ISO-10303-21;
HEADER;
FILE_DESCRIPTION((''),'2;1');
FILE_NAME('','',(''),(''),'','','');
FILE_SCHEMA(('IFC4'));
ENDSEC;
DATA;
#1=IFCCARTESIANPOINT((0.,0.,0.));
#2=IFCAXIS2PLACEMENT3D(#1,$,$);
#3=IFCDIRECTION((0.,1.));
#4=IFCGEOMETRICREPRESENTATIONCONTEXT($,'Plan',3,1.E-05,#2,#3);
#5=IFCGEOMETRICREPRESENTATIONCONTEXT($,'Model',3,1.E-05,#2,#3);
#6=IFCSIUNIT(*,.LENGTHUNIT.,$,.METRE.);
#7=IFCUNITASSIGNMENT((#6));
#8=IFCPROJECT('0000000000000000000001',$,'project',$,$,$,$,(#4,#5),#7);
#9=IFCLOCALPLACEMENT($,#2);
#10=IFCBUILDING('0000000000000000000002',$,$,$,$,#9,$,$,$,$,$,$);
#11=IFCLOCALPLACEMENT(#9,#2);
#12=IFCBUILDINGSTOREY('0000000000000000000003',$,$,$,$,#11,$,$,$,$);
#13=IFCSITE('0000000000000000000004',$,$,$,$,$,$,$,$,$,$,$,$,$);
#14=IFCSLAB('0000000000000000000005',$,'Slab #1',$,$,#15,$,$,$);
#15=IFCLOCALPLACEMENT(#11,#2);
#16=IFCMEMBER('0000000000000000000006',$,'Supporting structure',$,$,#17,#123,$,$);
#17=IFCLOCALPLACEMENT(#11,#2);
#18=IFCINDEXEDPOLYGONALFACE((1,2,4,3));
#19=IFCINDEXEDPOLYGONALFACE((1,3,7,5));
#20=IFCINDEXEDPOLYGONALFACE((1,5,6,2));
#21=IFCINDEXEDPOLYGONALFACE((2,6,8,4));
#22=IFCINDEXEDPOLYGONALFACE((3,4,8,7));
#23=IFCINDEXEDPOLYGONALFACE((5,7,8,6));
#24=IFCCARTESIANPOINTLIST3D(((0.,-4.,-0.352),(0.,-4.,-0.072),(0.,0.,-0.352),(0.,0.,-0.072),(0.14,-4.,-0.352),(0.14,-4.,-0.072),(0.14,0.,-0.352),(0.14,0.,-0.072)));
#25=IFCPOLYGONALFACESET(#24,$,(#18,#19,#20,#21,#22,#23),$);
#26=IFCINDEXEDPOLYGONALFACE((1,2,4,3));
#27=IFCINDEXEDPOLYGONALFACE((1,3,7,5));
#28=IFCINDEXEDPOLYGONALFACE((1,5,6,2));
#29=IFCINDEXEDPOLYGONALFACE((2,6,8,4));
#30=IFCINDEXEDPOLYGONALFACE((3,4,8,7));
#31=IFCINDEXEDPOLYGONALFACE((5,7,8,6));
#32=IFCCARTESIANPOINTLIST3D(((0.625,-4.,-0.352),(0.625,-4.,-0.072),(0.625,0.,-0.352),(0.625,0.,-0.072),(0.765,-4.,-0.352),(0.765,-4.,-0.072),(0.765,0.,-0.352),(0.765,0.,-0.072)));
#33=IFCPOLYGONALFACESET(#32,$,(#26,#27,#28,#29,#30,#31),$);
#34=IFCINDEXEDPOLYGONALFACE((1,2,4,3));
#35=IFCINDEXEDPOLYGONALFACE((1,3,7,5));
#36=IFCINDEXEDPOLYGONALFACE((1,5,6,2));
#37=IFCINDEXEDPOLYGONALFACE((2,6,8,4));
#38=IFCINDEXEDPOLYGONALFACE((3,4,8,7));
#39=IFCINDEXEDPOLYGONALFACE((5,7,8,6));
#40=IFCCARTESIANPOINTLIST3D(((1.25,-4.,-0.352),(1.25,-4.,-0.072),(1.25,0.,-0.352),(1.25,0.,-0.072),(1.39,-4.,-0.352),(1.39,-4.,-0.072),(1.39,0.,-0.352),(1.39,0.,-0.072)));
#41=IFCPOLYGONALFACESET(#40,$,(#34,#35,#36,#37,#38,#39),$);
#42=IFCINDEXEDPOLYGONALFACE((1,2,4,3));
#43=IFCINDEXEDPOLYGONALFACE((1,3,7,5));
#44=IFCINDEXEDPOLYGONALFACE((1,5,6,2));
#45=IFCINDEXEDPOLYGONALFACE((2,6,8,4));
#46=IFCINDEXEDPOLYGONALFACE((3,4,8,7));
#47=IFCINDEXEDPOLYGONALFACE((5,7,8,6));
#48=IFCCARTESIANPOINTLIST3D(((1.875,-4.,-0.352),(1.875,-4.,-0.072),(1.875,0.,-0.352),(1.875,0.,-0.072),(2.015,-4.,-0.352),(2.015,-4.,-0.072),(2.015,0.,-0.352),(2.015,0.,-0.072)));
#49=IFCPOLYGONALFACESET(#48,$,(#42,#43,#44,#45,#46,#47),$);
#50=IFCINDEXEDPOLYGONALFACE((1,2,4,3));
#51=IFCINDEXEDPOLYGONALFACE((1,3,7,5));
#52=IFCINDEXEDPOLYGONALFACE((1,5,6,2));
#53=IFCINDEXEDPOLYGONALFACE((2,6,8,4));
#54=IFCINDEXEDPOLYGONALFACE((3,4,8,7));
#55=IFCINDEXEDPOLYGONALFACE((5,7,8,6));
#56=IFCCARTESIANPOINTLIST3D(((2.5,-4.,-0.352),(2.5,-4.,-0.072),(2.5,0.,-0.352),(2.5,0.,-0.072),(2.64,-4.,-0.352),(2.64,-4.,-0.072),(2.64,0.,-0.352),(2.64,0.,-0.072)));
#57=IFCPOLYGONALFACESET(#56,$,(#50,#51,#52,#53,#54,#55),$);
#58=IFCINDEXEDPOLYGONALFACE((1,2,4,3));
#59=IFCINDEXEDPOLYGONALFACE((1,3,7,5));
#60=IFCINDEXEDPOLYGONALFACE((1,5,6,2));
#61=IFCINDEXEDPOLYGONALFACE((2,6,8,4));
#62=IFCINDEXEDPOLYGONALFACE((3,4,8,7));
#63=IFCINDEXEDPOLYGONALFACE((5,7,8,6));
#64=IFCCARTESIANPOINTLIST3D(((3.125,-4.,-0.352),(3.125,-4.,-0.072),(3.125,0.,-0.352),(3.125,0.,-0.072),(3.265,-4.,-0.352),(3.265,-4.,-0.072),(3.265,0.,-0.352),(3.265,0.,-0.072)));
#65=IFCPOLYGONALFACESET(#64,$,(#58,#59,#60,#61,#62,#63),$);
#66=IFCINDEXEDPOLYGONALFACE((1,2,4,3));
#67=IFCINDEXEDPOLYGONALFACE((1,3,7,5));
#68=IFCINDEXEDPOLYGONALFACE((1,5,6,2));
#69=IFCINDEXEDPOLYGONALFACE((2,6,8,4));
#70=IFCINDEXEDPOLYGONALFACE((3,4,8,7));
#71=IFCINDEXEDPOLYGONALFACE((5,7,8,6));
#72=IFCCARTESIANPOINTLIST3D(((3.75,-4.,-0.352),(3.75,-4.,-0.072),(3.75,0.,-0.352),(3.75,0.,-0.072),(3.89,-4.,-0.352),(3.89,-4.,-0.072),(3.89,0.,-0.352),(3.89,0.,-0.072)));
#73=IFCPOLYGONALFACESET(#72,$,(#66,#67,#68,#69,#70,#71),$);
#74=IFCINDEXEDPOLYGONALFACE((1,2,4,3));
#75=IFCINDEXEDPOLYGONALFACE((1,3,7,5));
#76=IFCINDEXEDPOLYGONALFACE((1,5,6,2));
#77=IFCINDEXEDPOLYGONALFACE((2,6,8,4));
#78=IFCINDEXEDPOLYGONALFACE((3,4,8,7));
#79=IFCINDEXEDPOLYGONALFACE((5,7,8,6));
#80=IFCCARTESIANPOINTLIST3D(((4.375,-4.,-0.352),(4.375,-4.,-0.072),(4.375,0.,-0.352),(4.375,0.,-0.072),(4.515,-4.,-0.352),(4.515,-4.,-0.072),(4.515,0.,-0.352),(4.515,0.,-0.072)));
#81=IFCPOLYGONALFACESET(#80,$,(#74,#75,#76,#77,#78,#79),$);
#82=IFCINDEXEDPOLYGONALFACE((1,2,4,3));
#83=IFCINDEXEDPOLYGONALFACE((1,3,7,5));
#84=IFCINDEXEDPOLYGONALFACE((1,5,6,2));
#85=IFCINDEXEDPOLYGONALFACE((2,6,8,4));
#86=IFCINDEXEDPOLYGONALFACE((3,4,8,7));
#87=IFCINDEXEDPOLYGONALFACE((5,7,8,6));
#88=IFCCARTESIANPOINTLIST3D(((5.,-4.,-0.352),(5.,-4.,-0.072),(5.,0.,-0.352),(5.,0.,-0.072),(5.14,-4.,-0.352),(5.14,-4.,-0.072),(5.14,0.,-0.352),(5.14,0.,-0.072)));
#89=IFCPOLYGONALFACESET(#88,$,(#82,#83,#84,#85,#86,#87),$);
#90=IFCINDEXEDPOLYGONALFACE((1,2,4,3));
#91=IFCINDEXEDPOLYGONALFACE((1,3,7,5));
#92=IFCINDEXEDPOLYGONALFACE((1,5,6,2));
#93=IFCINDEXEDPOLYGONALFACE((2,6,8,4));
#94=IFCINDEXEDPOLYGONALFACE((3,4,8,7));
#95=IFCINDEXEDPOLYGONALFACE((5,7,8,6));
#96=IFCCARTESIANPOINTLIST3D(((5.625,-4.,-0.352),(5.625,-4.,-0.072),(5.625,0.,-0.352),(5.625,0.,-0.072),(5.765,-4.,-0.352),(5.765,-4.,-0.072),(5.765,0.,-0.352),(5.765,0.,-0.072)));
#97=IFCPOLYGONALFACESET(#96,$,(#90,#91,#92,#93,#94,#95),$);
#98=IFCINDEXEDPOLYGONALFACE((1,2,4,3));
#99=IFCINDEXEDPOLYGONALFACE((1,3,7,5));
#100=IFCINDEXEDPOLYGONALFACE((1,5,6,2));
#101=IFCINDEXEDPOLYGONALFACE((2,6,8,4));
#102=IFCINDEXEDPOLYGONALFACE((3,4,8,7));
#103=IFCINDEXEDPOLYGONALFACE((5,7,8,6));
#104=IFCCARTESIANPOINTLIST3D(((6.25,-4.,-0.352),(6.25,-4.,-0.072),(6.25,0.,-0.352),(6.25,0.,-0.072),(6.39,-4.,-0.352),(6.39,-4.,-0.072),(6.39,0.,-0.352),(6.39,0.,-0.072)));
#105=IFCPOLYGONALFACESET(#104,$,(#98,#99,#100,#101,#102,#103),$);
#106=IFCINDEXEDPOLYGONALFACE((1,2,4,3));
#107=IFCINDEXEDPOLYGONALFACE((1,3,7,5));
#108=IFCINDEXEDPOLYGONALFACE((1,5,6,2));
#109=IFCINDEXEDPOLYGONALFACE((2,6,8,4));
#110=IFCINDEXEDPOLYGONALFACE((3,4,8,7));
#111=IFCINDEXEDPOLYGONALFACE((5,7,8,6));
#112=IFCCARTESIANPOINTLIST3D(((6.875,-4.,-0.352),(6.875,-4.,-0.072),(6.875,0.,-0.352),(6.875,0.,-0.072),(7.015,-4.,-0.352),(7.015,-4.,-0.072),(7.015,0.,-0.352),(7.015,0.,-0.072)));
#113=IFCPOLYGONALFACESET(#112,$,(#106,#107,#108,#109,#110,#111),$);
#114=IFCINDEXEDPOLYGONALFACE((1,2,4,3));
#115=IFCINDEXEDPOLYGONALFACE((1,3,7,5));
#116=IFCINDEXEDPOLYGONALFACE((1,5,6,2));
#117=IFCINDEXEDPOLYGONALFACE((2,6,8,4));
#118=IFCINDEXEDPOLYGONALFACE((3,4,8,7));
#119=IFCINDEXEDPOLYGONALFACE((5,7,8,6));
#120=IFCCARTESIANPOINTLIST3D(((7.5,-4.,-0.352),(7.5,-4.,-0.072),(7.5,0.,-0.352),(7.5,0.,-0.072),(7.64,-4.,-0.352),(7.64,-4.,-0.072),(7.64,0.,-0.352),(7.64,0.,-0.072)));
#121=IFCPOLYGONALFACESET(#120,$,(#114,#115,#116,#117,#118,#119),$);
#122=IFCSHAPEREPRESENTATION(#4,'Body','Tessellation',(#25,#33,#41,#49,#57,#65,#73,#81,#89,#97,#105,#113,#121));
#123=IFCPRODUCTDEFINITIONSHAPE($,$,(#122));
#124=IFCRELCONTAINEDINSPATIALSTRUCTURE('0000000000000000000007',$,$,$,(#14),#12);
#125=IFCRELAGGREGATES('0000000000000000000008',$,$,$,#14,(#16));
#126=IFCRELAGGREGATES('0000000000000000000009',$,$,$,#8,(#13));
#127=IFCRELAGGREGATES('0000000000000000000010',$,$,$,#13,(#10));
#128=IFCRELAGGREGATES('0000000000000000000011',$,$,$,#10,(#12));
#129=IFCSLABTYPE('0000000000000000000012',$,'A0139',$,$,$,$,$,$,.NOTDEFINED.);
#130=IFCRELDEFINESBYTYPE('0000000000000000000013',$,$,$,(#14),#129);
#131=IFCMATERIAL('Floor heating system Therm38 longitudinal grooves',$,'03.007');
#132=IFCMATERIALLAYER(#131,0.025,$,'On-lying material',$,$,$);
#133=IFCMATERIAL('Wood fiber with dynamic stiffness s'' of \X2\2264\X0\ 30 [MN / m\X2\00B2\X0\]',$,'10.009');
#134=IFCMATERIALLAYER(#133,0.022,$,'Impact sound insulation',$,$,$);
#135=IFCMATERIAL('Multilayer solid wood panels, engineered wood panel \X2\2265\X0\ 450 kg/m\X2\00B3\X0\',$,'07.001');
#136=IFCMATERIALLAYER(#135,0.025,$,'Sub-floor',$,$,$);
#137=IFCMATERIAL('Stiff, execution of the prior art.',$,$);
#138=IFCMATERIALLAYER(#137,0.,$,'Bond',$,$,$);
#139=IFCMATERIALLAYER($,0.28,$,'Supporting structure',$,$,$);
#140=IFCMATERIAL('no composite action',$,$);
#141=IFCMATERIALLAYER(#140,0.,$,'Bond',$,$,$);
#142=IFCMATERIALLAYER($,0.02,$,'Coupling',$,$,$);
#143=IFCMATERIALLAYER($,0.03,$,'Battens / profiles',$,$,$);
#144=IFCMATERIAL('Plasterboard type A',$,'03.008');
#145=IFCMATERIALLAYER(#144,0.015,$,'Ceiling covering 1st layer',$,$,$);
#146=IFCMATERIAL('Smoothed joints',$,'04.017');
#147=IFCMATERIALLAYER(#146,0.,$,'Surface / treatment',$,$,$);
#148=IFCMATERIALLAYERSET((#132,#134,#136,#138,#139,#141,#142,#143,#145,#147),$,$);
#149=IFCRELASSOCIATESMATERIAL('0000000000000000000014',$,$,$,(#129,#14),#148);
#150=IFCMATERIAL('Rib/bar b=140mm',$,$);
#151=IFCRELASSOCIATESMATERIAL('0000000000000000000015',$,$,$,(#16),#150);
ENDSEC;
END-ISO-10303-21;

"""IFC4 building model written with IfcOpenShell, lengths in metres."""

from ifc_helpers import new_model, si_unit, direction, frame, frame_2d, origin, place, context, project, spatial, rectangle, extrude, material, layer, layer_set, type_object, element, aggregate, save


model = new_model("IFC4")

# Units and contexts
plan_context = context("Plan", 3, precision=1e-05, world=origin(), true_north=direction((0.0, 1.0)))
model_context = context("Model", 3, precision=1e-05, world=origin(), true_north=direction((0.0, 1.0)))
ifc_project = project(units=[si_unit("LENGTHUNIT", "METRE")], contexts=[plan_context, model_context])

# Site, building, storey
site = spatial("IfcSite", under=ifc_project)
building_placement = place(None, origin())
building = spatial("IfcBuilding", under=site, at=building_placement)
storey_placement = place(building_placement, origin())
storey = spatial("IfcBuildingStorey", under=building, at=storey_placement)

# Slab, member
ifc_material_1 = material(Name="Floor heating system Therm38 longitudinal grooves", Category="03.007")
ifc_layer_1 = layer(ifc_material_1, 0.025, Name="On-lying material")
ifc_material_2 = material(Name="Wood fiber with dynamic stiffness s' of ≤ 30 [MN / m²]", Category="10.009")
ifc_layer_2 = layer(ifc_material_2, 0.022, Name="Impact sound insulation")
ifc_material_3 = material(Name="Multilayer solid wood panels, engineered wood panel ≥ 450 kg/m³", Category="07.001")
ifc_layer_3 = layer(ifc_material_3, 0.025, Name="Sub-floor")
ifc_material_4 = material(Name="Stiff, execution of the prior art.")
ifc_layer_4 = layer(ifc_material_4, 0.0, Name="Bond")
ifc_layer_5 = layer(None, 0.28, Name="Supporting structure")
ifc_material_5 = material(Name="no composite action")
ifc_layer_6 = layer(ifc_material_5, 0.0, Name="Bond")
ifc_layer_7 = layer(None, 0.02, Name="Coupling")
ifc_layer_8 = layer(None, 0.03, Name="Battens / profiles")
ifc_material_6 = material(Name="Plasterboard type A", Category="03.008")
ifc_layer_9 = layer(ifc_material_6, 0.015, Name="Ceiling covering 1st layer")
ifc_material_7 = material(Name="Smoothed joints", Category="04.017")
ifc_layer_10 = layer(ifc_material_7, 0.0, Name="Surface / treatment")
ifc_layer_set = layer_set([ifc_layer_1, ifc_layer_2, ifc_layer_3, ifc_layer_4, ifc_layer_5, ifc_layer_6, ifc_layer_7, ifc_layer_8, ifc_layer_9, ifc_layer_10])
slab_type = type_object("IfcSlabType", Name="A0139", PredefinedType="NOTDEFINED", material=ifc_layer_set)
slab_placement = place(None, frame((0.0, 0.0, 0.0), z_axis=(0.0, 0.0, -1.0), x_axis=(1.0, 0.0, 0.0)))
slab = element("IfcSlab", 1, at=slab_placement, inside=storey, type_object=slab_type, material=ifc_layer_set, Name="Slab #1")
ifc_material_8 = material(Name="Rib/bar b=140mm")
member_1_placement = place(slab_placement, origin())
member_1 = element("IfcMember", 2, at=member_1_placement, material=ifc_material_8, Name="Supporting structure", context=plan_context, shape_type="SweptSolid", body=[
    extrude(rectangle(XDim=0.14, YDim=0.28, at=frame_2d((0.07, 0.14), x_axis=(1.0, 0.0))), frame((0.0, 4.0, 0.072), z_axis=(0.0, -1.0, 0.0), x_axis=(1.0, 0.0, 0.0)), (0.0, 0.0, 1.0), 4.0),
    extrude(rectangle(XDim=0.14, YDim=0.28, at=frame_2d((0.07, 0.14), x_axis=(1.0, 0.0))), frame((0.625, 4.0, 0.072), z_axis=(0.0, -1.0, 0.0), x_axis=(1.0, 0.0, 0.0)), (0.0, 0.0, 1.0), 4.0),
    extrude(rectangle(XDim=0.14, YDim=0.28, at=frame_2d((0.07, 0.14), x_axis=(1.0, 0.0))), frame((1.25, 4.0, 0.072), z_axis=(0.0, -1.0, 0.0), x_axis=(1.0, 0.0, 0.0)), (0.0, 0.0, 1.0), 4.0),
    extrude(rectangle(XDim=0.14, YDim=0.28, at=frame_2d((0.07, 0.14), x_axis=(1.0, 0.0))), frame((1.875, 4.0, 0.072), z_axis=(0.0, -1.0, 0.0), x_axis=(1.0, 0.0, 0.0)), (0.0, 0.0, 1.0), 4.0),
    extrude(rectangle(XDim=0.14, YDim=0.28, at=frame_2d((0.07, 0.14), x_axis=(1.0, 0.0))), frame((2.5, 4.0, 0.072), z_axis=(0.0, -1.0, 0.0), x_axis=(1.0, 0.0, 0.0)), (0.0, 0.0, 1.0), 4.0),
    extrude(rectangle(XDim=0.14, YDim=0.28, at=frame_2d((0.07, 0.14), x_axis=(1.0, 0.0))), frame((3.125, 4.0, 0.072), z_axis=(0.0, -1.0, 0.0), x_axis=(1.0, 0.0, 0.0)), (0.0, 0.0, 1.0), 4.0),
    extrude(rectangle(XDim=0.14, YDim=0.28, at=frame_2d((0.07, 0.14), x_axis=(1.0, 0.0))), frame((3.75, 4.0, 0.072), z_axis=(0.0, -1.0, 0.0), x_axis=(1.0, 0.0, 0.0)), (0.0, 0.0, 1.0), 4.0),
    extrude(rectangle(XDim=0.14, YDim=0.28, at=frame_2d((0.07, 0.14), x_axis=(1.0, 0.0))), frame((4.375, 4.0, 0.072), z_axis=(0.0, -1.0, 0.0), x_axis=(1.0, 0.0, 0.0)), (0.0, 0.0, 1.0), 4.0),
    extrude(rectangle(XDim=0.14, YDim=0.28, at=frame_2d((0.07, 0.14), x_axis=(1.0, 0.0))), frame((5.0, 4.0, 0.072), z_axis=(0.0, -1.0, 0.0), x_axis=(1.0, 0.0, 0.0)), (0.0, 0.0, 1.0), 4.0),
    extrude(rectangle(XDim=0.14, YDim=0.28, at=frame_2d((0.07, 0.14), x_axis=(1.0, 0.0))), frame((5.625, 4.0, 0.072), z_axis=(0.0, -1.0, 0.0), x_axis=(1.0, 0.0, 0.0)), (0.0, 0.0, 1.0), 4.0),
    extrude(rectangle(XDim=0.14, YDim=0.28, at=frame_2d((0.07, 0.14), x_axis=(1.0, 0.0))), frame((6.25, 4.0, 0.072), z_axis=(0.0, -1.0, 0.0), x_axis=(1.0, 0.0, 0.0)), (0.0, 0.0, 1.0), 4.0),
    extrude(rectangle(XDim=0.14, YDim=0.28, at=frame_2d((0.07, 0.14), x_axis=(1.0, 0.0))), frame((6.875, 4.0, 0.072), z_axis=(0.0, -1.0, 0.0), x_axis=(1.0, 0.0, 0.0)), (0.0, 0.0, 1.0), 4.0),
    extrude(rectangle(XDim=0.14, YDim=0.28, at=frame_2d((0.07, 0.14), x_axis=(1.0, 0.0))), frame((7.5, 4.0, 0.072), z_axis=(0.0, -1.0, 0.0), x_axis=(1.0, 0.0, 0.0)), (0.0, 0.0, 1.0), 4.0),
])
aggregate(slab, [member_1])

save(model, "model.ifc")
